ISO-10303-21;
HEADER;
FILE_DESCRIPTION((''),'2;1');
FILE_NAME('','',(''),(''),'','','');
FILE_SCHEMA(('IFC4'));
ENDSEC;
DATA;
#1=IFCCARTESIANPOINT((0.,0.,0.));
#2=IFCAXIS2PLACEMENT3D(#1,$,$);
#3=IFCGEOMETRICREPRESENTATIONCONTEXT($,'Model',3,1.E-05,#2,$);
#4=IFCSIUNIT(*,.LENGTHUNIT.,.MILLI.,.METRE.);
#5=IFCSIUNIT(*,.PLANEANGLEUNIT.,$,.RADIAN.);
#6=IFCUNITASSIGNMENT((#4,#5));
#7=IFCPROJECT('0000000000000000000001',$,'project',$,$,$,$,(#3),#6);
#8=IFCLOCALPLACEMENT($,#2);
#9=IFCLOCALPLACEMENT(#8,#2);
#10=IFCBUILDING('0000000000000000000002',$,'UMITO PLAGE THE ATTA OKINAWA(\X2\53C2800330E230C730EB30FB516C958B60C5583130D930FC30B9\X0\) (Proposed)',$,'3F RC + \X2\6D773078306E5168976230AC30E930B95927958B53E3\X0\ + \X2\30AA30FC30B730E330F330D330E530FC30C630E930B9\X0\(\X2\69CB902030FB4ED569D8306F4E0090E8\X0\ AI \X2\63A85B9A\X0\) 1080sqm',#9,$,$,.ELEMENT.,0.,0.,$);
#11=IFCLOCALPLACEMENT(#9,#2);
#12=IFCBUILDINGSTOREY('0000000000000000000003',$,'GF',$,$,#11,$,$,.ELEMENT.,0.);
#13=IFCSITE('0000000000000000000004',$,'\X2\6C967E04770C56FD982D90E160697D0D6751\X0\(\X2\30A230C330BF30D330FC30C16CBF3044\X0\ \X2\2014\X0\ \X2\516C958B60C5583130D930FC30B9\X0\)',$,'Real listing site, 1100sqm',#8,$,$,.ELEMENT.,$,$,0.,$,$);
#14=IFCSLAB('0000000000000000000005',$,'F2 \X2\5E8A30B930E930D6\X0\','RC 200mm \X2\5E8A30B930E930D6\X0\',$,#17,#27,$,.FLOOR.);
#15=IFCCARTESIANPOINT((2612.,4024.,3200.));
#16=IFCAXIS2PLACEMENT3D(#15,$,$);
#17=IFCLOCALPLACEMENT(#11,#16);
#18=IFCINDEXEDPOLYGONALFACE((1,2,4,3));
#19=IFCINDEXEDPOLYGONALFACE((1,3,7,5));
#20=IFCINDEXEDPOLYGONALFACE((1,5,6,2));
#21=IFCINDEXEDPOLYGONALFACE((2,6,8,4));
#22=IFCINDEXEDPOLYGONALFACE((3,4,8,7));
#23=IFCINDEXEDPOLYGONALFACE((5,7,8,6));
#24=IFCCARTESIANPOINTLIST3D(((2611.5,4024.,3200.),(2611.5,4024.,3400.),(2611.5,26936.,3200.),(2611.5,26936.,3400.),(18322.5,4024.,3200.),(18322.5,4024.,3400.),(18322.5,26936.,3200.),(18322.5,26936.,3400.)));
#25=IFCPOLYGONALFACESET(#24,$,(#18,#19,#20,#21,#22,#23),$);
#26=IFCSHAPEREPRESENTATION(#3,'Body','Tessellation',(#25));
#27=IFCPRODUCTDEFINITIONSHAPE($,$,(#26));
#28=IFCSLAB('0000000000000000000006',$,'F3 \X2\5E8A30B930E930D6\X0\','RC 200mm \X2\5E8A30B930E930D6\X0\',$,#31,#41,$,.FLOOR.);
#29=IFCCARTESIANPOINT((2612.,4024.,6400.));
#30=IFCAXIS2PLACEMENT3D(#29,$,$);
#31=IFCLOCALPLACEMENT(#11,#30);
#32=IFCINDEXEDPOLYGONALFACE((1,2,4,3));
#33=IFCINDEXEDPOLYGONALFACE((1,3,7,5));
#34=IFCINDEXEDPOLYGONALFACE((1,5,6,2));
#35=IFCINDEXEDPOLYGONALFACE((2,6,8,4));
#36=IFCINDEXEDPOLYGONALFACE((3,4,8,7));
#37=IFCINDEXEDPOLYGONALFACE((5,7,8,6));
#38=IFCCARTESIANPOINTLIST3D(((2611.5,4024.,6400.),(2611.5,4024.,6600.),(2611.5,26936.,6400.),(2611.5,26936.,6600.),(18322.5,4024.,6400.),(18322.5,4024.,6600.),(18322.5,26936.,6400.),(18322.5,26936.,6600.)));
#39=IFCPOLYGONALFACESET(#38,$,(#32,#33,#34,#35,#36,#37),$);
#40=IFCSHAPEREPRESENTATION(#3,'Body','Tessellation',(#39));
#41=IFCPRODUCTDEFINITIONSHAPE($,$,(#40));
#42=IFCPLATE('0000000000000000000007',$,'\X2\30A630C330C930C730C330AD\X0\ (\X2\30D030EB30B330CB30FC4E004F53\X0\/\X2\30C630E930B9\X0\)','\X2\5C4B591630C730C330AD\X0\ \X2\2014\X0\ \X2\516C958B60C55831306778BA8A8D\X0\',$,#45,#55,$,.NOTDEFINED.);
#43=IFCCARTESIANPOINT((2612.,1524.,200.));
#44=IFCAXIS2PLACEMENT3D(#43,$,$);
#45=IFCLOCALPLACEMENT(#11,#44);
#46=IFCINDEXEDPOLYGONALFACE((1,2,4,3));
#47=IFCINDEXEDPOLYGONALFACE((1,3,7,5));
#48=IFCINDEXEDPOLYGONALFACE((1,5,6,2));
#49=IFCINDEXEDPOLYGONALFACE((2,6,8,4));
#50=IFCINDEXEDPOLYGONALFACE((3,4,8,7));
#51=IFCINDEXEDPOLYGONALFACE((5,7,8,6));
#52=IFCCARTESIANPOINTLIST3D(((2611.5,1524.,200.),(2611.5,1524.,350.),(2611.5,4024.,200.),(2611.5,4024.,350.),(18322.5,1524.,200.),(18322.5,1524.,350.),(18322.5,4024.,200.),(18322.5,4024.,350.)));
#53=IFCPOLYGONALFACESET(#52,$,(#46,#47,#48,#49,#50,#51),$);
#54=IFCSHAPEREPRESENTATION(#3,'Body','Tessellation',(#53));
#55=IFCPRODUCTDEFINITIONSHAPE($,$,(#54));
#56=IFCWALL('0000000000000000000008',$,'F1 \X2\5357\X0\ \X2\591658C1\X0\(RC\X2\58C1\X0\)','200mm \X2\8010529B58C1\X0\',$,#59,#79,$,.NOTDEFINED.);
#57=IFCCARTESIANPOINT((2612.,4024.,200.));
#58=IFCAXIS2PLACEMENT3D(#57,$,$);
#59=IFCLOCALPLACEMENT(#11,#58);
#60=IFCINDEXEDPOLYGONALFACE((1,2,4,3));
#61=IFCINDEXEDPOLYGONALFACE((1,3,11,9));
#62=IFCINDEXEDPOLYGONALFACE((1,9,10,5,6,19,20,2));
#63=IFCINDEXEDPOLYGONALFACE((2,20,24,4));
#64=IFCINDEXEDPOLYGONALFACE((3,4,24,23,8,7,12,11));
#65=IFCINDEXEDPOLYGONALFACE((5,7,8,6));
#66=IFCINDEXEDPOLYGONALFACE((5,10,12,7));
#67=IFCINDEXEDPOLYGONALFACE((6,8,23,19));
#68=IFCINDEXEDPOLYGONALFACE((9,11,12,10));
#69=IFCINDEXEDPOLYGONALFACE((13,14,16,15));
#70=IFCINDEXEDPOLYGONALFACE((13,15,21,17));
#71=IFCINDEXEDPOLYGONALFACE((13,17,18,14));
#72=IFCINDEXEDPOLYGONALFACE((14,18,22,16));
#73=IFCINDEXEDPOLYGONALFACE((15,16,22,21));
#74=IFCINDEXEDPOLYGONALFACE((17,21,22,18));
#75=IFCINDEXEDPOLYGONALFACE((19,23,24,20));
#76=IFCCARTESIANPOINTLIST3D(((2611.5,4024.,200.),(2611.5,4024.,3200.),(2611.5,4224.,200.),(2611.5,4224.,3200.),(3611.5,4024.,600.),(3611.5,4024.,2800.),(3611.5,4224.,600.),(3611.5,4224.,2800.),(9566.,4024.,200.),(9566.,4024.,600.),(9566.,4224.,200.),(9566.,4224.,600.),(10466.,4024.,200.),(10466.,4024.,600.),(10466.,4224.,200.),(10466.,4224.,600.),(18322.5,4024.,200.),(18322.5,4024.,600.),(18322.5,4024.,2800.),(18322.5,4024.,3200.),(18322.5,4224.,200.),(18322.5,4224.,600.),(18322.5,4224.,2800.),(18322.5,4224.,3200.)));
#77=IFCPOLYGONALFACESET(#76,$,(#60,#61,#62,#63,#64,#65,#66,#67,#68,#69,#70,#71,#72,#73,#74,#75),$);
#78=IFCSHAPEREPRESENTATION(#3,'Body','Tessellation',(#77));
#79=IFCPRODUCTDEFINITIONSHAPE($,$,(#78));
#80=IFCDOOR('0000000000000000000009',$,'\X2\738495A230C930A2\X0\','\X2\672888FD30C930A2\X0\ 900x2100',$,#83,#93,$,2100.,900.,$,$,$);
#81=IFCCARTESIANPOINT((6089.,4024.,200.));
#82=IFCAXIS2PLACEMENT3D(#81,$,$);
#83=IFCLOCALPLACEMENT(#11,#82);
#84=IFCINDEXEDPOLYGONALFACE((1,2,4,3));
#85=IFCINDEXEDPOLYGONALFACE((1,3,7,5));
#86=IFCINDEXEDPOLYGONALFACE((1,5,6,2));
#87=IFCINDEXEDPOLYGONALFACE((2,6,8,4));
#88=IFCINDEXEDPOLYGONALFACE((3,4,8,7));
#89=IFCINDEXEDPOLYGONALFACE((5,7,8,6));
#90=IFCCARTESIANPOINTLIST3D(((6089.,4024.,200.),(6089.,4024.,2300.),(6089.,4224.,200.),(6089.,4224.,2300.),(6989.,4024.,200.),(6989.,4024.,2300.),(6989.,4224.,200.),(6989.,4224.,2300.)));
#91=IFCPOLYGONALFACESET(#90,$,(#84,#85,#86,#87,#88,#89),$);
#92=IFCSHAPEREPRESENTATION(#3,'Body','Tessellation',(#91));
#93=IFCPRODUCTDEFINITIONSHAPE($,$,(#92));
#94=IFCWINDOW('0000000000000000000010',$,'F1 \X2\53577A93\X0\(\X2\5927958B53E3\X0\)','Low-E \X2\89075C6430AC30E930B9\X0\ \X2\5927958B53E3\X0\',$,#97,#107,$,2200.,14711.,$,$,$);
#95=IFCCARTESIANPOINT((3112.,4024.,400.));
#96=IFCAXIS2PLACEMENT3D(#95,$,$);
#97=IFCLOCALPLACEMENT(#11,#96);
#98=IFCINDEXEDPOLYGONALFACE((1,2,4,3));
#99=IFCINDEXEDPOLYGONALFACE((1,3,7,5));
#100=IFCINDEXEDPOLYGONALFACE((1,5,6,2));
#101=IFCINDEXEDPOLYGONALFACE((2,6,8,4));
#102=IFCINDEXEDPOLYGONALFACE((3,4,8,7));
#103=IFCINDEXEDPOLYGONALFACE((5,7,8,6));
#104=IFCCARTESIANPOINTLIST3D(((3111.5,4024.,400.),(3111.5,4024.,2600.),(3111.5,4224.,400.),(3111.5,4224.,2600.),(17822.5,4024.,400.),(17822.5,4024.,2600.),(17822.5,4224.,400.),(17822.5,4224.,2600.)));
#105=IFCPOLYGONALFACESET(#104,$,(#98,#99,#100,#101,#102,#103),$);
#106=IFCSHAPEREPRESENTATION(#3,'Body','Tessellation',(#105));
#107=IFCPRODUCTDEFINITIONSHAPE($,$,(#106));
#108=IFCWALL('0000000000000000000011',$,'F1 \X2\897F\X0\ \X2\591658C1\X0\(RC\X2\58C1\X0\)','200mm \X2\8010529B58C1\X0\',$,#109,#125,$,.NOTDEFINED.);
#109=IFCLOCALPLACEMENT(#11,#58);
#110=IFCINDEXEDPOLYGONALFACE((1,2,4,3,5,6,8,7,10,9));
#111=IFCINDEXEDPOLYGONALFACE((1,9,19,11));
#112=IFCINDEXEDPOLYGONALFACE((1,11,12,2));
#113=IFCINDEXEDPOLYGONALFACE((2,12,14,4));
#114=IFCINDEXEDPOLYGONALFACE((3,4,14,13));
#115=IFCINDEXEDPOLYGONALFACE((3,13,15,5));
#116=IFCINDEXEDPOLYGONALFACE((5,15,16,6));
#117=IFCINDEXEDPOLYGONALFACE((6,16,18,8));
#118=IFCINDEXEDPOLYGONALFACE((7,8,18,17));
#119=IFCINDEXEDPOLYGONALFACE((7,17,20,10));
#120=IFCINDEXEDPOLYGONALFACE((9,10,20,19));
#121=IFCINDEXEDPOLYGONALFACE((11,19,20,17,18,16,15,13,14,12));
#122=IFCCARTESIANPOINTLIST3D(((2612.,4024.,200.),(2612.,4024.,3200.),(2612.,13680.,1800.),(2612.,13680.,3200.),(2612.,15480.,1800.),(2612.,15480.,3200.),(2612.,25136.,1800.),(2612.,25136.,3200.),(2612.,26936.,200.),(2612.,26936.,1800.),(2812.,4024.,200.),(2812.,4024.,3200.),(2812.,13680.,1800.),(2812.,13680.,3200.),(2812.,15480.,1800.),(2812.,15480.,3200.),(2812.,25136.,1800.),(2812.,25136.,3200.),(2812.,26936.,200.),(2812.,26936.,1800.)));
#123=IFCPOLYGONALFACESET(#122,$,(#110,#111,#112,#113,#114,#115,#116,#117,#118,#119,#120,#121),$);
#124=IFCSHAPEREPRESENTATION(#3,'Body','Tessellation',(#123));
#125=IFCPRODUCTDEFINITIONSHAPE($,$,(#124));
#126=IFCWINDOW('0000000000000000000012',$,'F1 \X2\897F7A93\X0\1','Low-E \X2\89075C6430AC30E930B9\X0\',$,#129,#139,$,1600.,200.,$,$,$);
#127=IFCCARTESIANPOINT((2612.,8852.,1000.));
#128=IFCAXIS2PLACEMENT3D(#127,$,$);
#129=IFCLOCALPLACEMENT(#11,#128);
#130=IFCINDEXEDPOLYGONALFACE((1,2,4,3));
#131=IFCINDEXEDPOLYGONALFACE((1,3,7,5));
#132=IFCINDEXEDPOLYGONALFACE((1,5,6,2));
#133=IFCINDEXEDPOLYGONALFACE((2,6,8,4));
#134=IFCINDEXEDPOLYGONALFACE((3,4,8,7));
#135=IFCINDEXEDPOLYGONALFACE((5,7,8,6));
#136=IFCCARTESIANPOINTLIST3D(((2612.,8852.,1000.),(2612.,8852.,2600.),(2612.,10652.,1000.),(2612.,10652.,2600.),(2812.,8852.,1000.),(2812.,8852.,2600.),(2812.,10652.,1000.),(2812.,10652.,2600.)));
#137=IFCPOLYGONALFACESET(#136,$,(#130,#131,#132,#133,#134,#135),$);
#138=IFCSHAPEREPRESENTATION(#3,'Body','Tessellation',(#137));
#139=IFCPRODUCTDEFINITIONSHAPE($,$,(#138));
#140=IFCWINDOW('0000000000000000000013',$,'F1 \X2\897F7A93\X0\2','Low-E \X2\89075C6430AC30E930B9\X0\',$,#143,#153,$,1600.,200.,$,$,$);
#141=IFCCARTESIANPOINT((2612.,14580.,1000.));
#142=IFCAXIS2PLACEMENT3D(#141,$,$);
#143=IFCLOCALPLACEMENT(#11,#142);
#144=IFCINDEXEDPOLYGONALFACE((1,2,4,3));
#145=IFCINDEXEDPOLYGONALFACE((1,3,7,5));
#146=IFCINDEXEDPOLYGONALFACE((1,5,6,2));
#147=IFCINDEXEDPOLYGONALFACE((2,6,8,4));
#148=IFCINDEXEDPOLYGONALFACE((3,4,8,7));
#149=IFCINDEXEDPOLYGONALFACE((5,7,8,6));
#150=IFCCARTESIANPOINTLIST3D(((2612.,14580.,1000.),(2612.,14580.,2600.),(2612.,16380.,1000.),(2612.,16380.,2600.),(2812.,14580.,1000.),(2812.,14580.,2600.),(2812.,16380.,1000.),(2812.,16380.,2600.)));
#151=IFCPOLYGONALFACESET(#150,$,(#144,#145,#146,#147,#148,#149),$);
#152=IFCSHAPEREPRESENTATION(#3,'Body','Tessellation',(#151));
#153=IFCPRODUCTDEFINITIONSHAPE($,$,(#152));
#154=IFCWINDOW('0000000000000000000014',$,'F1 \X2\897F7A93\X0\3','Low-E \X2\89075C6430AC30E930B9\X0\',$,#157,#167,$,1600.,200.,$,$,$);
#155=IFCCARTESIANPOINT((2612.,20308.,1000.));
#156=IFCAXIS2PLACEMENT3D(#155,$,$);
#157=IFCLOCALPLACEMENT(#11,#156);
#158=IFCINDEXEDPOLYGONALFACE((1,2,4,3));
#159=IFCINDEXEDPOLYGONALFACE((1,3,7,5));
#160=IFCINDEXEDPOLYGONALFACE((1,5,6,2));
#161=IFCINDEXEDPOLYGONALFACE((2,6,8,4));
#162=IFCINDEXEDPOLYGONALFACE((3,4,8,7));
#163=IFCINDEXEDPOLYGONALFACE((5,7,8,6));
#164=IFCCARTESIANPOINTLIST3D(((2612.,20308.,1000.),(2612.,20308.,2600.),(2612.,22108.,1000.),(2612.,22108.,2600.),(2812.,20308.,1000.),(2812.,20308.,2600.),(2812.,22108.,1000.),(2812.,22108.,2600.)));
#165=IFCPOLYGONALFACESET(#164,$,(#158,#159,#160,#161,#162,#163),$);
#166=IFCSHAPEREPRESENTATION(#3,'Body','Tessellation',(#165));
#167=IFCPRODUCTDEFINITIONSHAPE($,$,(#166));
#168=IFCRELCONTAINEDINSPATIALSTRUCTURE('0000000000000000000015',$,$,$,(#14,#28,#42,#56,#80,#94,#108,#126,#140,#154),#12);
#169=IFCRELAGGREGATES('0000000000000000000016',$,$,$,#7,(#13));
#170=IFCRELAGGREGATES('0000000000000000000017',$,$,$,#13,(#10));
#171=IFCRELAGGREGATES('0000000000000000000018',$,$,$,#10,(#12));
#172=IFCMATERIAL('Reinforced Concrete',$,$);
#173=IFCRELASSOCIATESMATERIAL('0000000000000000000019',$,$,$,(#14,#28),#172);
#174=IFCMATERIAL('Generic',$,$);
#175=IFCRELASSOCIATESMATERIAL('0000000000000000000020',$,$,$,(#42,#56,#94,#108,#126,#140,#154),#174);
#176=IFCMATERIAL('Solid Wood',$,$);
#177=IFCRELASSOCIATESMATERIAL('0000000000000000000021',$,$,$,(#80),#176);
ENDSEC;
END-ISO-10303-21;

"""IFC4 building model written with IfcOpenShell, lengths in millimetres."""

from ifc_helpers import new_model, si_unit, frame, frame_2d, origin, place, context, project, spatial, rectangle, extrude, material, element, fill, save


model = new_model("IFC4")

# Units and contexts
model_context = context("Model", 3, precision=1e-05, world=origin())
ifc_project = project(units=[si_unit("LENGTHUNIT", "METRE", prefix="MILLI"), si_unit("PLANEANGLEUNIT", "RADIAN")], contexts=[model_context])

# Site, building, storey
site_placement = place(None, origin())
site = spatial("IfcSite", under=ifc_project, at=site_placement, Name="沖縄県国頭郡恩納村(アッタビーチ沿い — 公開情報ベース)", ObjectType="Real listing site, 1100sqm", CompositionType="ELEMENT", RefElevation=0.0)
building_placement = place(site_placement, origin())
building = spatial("IfcBuilding", under=site, at=building_placement, Name="UMITO PLAGE THE ATTA OKINAWA(参考モデル・公開情報ベース) (Proposed)", ObjectType="3F RC + 海への全面ガラス大開口 + オーシャンビューテラス(構造・仕様は一部 AI 推定) 1080sqm", CompositionType="ELEMENT", ElevationOfRefHeight=0.0, ElevationOfTerrain=0.0)
storey_placement = place(building_placement, origin())
storey = spatial("IfcBuildingStorey", under=building, at=storey_placement, Name="GF", CompositionType="ELEMENT", Elevation=0.0)

# Slabs
ifc_material_1 = material(Name="Reinforced Concrete")
slab_1_placement = place(storey_placement, frame((2612.0, 4024.0, 3200.0)))
element("IfcSlab", 1, at=slab_1_placement, inside=storey, material=ifc_material_1, Name="F2 床スラブ", Description="RC 200mm 床スラブ", PredefinedType="FLOOR", context=model_context, shape_type="SweptSolid", body=[
    extrude(rectangle(XDim=15711.0, YDim=22912.0, at=frame_2d((7855.0, 11456.0))), frame((2612.0, 4024.0, 3200.0)), (0.0, 0.0, 1.0), 200.0),
])
slab_2_placement = place(storey_placement, frame((2612.0, 4024.0, 6400.0)))
element("IfcSlab", 2, at=slab_2_placement, inside=storey, material=ifc_material_1, Name="F3 床スラブ", Description="RC 200mm 床スラブ", PredefinedType="FLOOR", context=model_context, shape_type="SweptSolid", body=[
    extrude(rectangle(XDim=15711.0, YDim=22912.0, at=frame_2d((7855.0, 11456.0))), frame((2612.0, 4024.0, 6400.0)), (0.0, 0.0, 1.0), 200.0),
])

# Plate
ifc_material_2 = material(Name="Generic")
plate_placement = place(storey_placement, frame((2612.0, 1524.0, 200.0)))
element("IfcPlate", 3, at=plate_placement, inside=storey, material=ifc_material_2, Name="ウッドデッキ (バルコニー一体/テラス)", Description="屋外デッキ — 公開情報で確認", PredefinedType="NOTDEFINED", context=model_context, shape_type="SweptSolid", body=[
    extrude(rectangle(XDim=15711.0, YDim=2500.0, at=frame_2d((7855.0, 1250.0))), frame((2612.0, 1524.0, 200.0)), (0.0, 0.0, 1.0), 150.0),
])

# Wall, openings, door, window
wall_1_placement = place(storey_placement, frame((2612.0, 4024.0, 200.0)))
wall_1 = element("IfcWall", 4, at=wall_1_placement, inside=storey, material=ifc_material_2, Name="F1 南 外壁(RC壁)", Description="200mm 耐力壁", PredefinedType="NOTDEFINED", context=model_context, shape_type="SweptSolid", body=[
    extrude(rectangle(XDim=15711.0, YDim=200.0, at=frame_2d((7855.0, 100.0))), frame((2612.0, 4024.0, 200.0)), (0.0, 0.0, 1.0), 3000.0),
])
opening_1_placement = place(storey_placement, frame((6089.0, 4024.0, 200.0)))
opening_1 = element("IfcOpeningElement", 5, at=opening_1_placement, cuts=wall_1, PredefinedType="NOTDEFINED", context=model_context, shape_type="SweptSolid", body=[
    extrude(rectangle(XDim=900.0, YDim=200.0, at=frame_2d((450.0, 100.0))), frame((6089.0, 4024.0, 200.0)), (0.0, 0.0, 1.0), 2100.0),
])
opening_2_placement = place(storey_placement, frame((3112.0, 4024.0, 400.0)))
opening_2 = element("IfcOpeningElement", 6, at=opening_2_placement, cuts=wall_1, PredefinedType="NOTDEFINED", context=model_context, shape_type="SweptSolid", body=[
    extrude(rectangle(XDim=14711.0, YDim=200.0, at=frame_2d((7355.0, 100.0))), frame((3112.0, 4024.0, 400.0)), (0.0, 0.0, 1.0), 2200.0),
])
ifc_material_3 = material(Name="Solid Wood")
door_placement = place(storey_placement, frame((6089.0, 4024.0, 200.0)))
door = element("IfcDoor", 7, at=door_placement, inside=storey, material=ifc_material_3, Name="玄関ドア", Description="木製ドア 900x2100", OverallHeight=2100.0, OverallWidth=900.0, context=model_context, shape_type="SweptSolid", body=[
    extrude(rectangle(XDim=900.0, YDim=200.0, at=frame_2d((450.0, 100.0))), frame((6089.0, 4024.0, 200.0)), (0.0, 0.0, 1.0), 2100.0),
])
fill(opening_1, door)
window_1_placement = place(storey_placement, frame((3112.0, 4024.0, 400.0)))
window_1 = element("IfcWindow", 8, at=window_1_placement, inside=storey, material=ifc_material_2, Name="F1 南窓(大開口)", Description="Low-E 複層ガラス 大開口", OverallHeight=2200.0, OverallWidth=14711.0, context=model_context, shape_type="SweptSolid", body=[
    extrude(rectangle(XDim=14711.0, YDim=200.0, at=frame_2d((7355.0, 100.0))), frame((3112.0, 4024.0, 400.0)), (0.0, 0.0, 1.0), 2200.0),
])
fill(opening_2, window_1)

# Wall, openings, windows
wall_2_placement = place(storey_placement, frame((2612.0, 4024.0, 200.0)))
wall_2 = element("IfcWall", 9, at=wall_2_placement, inside=storey, material=ifc_material_2, Name="F1 西 外壁(RC壁)", Description="200mm 耐力壁", PredefinedType="NOTDEFINED", context=model_context, shape_type="SweptSolid", body=[
    extrude(rectangle(XDim=200.0, YDim=22912.0, at=frame_2d((100.0, 11456.0))), frame((2612.0, 4024.0, 200.0)), (0.0, 0.0, 1.0), 3000.0),
])
opening_3_placement = place(storey_placement, frame((2612.0, 8852.0, 1000.0)))
opening_3 = element("IfcOpeningElement", 10, at=opening_3_placement, cuts=wall_2, PredefinedType="NOTDEFINED", context=model_context, shape_type="SweptSolid", body=[
    extrude(rectangle(XDim=200.0, YDim=1800.0, at=frame_2d((100.0, 900.0))), frame((2612.0, 8852.0, 1000.0)), (0.0, 0.0, 1.0), 1600.0),
])
opening_4_placement = place(storey_placement, frame((2612.0, 14580.0, 1000.0)))
opening_4 = element("IfcOpeningElement", 11, at=opening_4_placement, cuts=wall_2, PredefinedType="NOTDEFINED", context=model_context, shape_type="SweptSolid", body=[
    extrude(rectangle(XDim=200.0, YDim=1800.0, at=frame_2d((100.0, 900.0))), frame((2612.0, 14580.0, 1000.0)), (0.0, 0.0, 1.0), 1600.0),
])
opening_5_placement = place(storey_placement, frame((2612.0, 20308.0, 1000.0)))
opening_5 = element("IfcOpeningElement", 12, at=opening_5_placement, cuts=wall_2, PredefinedType="NOTDEFINED", context=model_context, shape_type="SweptSolid", body=[
    extrude(rectangle(XDim=200.0, YDim=1800.0, at=frame_2d((100.0, 900.0))), frame((2612.0, 20308.0, 1000.0)), (0.0, 0.0, 1.0), 1600.0),
])
window_2_placement = place(storey_placement, frame((2612.0, 8852.0, 1000.0)))
window_2 = element("IfcWindow", 13, at=window_2_placement, inside=storey, material=ifc_material_2, Name="F1 西窓1", Description="Low-E 複層ガラス", OverallHeight=1600.0, OverallWidth=200.0, context=model_context, shape_type="SweptSolid", body=[
    extrude(rectangle(XDim=200.0, YDim=1800.0, at=frame_2d((100.0, 900.0))), frame((2612.0, 8852.0, 1000.0)), (0.0, 0.0, 1.0), 1600.0),
])
fill(opening_3, window_2)
window_3_placement = place(storey_placement, frame((2612.0, 14580.0, 1000.0)))
window_3 = element("IfcWindow", 14, at=window_3_placement, inside=storey, material=ifc_material_2, Name="F1 西窓2", Description="Low-E 複層ガラス", OverallHeight=1600.0, OverallWidth=200.0, context=model_context, shape_type="SweptSolid", body=[
    extrude(rectangle(XDim=200.0, YDim=1800.0, at=frame_2d((100.0, 900.0))), frame((2612.0, 14580.0, 1000.0)), (0.0, 0.0, 1.0), 1600.0),
])
fill(opening_4, window_3)
window_4_placement = place(storey_placement, frame((2612.0, 20308.0, 1000.0)))
window_4 = element("IfcWindow", 15, at=window_4_placement, inside=storey, material=ifc_material_2, Name="F1 西窓3", Description="Low-E 複層ガラス", OverallHeight=1600.0, OverallWidth=200.0, context=model_context, shape_type="SweptSolid", body=[
    extrude(rectangle(XDim=200.0, YDim=1800.0, at=frame_2d((100.0, 900.0))), frame((2612.0, 20308.0, 1000.0)), (0.0, 0.0, 1.0), 1600.0),
])
fill(opening_5, window_4)

save(model, "model.ifc")
